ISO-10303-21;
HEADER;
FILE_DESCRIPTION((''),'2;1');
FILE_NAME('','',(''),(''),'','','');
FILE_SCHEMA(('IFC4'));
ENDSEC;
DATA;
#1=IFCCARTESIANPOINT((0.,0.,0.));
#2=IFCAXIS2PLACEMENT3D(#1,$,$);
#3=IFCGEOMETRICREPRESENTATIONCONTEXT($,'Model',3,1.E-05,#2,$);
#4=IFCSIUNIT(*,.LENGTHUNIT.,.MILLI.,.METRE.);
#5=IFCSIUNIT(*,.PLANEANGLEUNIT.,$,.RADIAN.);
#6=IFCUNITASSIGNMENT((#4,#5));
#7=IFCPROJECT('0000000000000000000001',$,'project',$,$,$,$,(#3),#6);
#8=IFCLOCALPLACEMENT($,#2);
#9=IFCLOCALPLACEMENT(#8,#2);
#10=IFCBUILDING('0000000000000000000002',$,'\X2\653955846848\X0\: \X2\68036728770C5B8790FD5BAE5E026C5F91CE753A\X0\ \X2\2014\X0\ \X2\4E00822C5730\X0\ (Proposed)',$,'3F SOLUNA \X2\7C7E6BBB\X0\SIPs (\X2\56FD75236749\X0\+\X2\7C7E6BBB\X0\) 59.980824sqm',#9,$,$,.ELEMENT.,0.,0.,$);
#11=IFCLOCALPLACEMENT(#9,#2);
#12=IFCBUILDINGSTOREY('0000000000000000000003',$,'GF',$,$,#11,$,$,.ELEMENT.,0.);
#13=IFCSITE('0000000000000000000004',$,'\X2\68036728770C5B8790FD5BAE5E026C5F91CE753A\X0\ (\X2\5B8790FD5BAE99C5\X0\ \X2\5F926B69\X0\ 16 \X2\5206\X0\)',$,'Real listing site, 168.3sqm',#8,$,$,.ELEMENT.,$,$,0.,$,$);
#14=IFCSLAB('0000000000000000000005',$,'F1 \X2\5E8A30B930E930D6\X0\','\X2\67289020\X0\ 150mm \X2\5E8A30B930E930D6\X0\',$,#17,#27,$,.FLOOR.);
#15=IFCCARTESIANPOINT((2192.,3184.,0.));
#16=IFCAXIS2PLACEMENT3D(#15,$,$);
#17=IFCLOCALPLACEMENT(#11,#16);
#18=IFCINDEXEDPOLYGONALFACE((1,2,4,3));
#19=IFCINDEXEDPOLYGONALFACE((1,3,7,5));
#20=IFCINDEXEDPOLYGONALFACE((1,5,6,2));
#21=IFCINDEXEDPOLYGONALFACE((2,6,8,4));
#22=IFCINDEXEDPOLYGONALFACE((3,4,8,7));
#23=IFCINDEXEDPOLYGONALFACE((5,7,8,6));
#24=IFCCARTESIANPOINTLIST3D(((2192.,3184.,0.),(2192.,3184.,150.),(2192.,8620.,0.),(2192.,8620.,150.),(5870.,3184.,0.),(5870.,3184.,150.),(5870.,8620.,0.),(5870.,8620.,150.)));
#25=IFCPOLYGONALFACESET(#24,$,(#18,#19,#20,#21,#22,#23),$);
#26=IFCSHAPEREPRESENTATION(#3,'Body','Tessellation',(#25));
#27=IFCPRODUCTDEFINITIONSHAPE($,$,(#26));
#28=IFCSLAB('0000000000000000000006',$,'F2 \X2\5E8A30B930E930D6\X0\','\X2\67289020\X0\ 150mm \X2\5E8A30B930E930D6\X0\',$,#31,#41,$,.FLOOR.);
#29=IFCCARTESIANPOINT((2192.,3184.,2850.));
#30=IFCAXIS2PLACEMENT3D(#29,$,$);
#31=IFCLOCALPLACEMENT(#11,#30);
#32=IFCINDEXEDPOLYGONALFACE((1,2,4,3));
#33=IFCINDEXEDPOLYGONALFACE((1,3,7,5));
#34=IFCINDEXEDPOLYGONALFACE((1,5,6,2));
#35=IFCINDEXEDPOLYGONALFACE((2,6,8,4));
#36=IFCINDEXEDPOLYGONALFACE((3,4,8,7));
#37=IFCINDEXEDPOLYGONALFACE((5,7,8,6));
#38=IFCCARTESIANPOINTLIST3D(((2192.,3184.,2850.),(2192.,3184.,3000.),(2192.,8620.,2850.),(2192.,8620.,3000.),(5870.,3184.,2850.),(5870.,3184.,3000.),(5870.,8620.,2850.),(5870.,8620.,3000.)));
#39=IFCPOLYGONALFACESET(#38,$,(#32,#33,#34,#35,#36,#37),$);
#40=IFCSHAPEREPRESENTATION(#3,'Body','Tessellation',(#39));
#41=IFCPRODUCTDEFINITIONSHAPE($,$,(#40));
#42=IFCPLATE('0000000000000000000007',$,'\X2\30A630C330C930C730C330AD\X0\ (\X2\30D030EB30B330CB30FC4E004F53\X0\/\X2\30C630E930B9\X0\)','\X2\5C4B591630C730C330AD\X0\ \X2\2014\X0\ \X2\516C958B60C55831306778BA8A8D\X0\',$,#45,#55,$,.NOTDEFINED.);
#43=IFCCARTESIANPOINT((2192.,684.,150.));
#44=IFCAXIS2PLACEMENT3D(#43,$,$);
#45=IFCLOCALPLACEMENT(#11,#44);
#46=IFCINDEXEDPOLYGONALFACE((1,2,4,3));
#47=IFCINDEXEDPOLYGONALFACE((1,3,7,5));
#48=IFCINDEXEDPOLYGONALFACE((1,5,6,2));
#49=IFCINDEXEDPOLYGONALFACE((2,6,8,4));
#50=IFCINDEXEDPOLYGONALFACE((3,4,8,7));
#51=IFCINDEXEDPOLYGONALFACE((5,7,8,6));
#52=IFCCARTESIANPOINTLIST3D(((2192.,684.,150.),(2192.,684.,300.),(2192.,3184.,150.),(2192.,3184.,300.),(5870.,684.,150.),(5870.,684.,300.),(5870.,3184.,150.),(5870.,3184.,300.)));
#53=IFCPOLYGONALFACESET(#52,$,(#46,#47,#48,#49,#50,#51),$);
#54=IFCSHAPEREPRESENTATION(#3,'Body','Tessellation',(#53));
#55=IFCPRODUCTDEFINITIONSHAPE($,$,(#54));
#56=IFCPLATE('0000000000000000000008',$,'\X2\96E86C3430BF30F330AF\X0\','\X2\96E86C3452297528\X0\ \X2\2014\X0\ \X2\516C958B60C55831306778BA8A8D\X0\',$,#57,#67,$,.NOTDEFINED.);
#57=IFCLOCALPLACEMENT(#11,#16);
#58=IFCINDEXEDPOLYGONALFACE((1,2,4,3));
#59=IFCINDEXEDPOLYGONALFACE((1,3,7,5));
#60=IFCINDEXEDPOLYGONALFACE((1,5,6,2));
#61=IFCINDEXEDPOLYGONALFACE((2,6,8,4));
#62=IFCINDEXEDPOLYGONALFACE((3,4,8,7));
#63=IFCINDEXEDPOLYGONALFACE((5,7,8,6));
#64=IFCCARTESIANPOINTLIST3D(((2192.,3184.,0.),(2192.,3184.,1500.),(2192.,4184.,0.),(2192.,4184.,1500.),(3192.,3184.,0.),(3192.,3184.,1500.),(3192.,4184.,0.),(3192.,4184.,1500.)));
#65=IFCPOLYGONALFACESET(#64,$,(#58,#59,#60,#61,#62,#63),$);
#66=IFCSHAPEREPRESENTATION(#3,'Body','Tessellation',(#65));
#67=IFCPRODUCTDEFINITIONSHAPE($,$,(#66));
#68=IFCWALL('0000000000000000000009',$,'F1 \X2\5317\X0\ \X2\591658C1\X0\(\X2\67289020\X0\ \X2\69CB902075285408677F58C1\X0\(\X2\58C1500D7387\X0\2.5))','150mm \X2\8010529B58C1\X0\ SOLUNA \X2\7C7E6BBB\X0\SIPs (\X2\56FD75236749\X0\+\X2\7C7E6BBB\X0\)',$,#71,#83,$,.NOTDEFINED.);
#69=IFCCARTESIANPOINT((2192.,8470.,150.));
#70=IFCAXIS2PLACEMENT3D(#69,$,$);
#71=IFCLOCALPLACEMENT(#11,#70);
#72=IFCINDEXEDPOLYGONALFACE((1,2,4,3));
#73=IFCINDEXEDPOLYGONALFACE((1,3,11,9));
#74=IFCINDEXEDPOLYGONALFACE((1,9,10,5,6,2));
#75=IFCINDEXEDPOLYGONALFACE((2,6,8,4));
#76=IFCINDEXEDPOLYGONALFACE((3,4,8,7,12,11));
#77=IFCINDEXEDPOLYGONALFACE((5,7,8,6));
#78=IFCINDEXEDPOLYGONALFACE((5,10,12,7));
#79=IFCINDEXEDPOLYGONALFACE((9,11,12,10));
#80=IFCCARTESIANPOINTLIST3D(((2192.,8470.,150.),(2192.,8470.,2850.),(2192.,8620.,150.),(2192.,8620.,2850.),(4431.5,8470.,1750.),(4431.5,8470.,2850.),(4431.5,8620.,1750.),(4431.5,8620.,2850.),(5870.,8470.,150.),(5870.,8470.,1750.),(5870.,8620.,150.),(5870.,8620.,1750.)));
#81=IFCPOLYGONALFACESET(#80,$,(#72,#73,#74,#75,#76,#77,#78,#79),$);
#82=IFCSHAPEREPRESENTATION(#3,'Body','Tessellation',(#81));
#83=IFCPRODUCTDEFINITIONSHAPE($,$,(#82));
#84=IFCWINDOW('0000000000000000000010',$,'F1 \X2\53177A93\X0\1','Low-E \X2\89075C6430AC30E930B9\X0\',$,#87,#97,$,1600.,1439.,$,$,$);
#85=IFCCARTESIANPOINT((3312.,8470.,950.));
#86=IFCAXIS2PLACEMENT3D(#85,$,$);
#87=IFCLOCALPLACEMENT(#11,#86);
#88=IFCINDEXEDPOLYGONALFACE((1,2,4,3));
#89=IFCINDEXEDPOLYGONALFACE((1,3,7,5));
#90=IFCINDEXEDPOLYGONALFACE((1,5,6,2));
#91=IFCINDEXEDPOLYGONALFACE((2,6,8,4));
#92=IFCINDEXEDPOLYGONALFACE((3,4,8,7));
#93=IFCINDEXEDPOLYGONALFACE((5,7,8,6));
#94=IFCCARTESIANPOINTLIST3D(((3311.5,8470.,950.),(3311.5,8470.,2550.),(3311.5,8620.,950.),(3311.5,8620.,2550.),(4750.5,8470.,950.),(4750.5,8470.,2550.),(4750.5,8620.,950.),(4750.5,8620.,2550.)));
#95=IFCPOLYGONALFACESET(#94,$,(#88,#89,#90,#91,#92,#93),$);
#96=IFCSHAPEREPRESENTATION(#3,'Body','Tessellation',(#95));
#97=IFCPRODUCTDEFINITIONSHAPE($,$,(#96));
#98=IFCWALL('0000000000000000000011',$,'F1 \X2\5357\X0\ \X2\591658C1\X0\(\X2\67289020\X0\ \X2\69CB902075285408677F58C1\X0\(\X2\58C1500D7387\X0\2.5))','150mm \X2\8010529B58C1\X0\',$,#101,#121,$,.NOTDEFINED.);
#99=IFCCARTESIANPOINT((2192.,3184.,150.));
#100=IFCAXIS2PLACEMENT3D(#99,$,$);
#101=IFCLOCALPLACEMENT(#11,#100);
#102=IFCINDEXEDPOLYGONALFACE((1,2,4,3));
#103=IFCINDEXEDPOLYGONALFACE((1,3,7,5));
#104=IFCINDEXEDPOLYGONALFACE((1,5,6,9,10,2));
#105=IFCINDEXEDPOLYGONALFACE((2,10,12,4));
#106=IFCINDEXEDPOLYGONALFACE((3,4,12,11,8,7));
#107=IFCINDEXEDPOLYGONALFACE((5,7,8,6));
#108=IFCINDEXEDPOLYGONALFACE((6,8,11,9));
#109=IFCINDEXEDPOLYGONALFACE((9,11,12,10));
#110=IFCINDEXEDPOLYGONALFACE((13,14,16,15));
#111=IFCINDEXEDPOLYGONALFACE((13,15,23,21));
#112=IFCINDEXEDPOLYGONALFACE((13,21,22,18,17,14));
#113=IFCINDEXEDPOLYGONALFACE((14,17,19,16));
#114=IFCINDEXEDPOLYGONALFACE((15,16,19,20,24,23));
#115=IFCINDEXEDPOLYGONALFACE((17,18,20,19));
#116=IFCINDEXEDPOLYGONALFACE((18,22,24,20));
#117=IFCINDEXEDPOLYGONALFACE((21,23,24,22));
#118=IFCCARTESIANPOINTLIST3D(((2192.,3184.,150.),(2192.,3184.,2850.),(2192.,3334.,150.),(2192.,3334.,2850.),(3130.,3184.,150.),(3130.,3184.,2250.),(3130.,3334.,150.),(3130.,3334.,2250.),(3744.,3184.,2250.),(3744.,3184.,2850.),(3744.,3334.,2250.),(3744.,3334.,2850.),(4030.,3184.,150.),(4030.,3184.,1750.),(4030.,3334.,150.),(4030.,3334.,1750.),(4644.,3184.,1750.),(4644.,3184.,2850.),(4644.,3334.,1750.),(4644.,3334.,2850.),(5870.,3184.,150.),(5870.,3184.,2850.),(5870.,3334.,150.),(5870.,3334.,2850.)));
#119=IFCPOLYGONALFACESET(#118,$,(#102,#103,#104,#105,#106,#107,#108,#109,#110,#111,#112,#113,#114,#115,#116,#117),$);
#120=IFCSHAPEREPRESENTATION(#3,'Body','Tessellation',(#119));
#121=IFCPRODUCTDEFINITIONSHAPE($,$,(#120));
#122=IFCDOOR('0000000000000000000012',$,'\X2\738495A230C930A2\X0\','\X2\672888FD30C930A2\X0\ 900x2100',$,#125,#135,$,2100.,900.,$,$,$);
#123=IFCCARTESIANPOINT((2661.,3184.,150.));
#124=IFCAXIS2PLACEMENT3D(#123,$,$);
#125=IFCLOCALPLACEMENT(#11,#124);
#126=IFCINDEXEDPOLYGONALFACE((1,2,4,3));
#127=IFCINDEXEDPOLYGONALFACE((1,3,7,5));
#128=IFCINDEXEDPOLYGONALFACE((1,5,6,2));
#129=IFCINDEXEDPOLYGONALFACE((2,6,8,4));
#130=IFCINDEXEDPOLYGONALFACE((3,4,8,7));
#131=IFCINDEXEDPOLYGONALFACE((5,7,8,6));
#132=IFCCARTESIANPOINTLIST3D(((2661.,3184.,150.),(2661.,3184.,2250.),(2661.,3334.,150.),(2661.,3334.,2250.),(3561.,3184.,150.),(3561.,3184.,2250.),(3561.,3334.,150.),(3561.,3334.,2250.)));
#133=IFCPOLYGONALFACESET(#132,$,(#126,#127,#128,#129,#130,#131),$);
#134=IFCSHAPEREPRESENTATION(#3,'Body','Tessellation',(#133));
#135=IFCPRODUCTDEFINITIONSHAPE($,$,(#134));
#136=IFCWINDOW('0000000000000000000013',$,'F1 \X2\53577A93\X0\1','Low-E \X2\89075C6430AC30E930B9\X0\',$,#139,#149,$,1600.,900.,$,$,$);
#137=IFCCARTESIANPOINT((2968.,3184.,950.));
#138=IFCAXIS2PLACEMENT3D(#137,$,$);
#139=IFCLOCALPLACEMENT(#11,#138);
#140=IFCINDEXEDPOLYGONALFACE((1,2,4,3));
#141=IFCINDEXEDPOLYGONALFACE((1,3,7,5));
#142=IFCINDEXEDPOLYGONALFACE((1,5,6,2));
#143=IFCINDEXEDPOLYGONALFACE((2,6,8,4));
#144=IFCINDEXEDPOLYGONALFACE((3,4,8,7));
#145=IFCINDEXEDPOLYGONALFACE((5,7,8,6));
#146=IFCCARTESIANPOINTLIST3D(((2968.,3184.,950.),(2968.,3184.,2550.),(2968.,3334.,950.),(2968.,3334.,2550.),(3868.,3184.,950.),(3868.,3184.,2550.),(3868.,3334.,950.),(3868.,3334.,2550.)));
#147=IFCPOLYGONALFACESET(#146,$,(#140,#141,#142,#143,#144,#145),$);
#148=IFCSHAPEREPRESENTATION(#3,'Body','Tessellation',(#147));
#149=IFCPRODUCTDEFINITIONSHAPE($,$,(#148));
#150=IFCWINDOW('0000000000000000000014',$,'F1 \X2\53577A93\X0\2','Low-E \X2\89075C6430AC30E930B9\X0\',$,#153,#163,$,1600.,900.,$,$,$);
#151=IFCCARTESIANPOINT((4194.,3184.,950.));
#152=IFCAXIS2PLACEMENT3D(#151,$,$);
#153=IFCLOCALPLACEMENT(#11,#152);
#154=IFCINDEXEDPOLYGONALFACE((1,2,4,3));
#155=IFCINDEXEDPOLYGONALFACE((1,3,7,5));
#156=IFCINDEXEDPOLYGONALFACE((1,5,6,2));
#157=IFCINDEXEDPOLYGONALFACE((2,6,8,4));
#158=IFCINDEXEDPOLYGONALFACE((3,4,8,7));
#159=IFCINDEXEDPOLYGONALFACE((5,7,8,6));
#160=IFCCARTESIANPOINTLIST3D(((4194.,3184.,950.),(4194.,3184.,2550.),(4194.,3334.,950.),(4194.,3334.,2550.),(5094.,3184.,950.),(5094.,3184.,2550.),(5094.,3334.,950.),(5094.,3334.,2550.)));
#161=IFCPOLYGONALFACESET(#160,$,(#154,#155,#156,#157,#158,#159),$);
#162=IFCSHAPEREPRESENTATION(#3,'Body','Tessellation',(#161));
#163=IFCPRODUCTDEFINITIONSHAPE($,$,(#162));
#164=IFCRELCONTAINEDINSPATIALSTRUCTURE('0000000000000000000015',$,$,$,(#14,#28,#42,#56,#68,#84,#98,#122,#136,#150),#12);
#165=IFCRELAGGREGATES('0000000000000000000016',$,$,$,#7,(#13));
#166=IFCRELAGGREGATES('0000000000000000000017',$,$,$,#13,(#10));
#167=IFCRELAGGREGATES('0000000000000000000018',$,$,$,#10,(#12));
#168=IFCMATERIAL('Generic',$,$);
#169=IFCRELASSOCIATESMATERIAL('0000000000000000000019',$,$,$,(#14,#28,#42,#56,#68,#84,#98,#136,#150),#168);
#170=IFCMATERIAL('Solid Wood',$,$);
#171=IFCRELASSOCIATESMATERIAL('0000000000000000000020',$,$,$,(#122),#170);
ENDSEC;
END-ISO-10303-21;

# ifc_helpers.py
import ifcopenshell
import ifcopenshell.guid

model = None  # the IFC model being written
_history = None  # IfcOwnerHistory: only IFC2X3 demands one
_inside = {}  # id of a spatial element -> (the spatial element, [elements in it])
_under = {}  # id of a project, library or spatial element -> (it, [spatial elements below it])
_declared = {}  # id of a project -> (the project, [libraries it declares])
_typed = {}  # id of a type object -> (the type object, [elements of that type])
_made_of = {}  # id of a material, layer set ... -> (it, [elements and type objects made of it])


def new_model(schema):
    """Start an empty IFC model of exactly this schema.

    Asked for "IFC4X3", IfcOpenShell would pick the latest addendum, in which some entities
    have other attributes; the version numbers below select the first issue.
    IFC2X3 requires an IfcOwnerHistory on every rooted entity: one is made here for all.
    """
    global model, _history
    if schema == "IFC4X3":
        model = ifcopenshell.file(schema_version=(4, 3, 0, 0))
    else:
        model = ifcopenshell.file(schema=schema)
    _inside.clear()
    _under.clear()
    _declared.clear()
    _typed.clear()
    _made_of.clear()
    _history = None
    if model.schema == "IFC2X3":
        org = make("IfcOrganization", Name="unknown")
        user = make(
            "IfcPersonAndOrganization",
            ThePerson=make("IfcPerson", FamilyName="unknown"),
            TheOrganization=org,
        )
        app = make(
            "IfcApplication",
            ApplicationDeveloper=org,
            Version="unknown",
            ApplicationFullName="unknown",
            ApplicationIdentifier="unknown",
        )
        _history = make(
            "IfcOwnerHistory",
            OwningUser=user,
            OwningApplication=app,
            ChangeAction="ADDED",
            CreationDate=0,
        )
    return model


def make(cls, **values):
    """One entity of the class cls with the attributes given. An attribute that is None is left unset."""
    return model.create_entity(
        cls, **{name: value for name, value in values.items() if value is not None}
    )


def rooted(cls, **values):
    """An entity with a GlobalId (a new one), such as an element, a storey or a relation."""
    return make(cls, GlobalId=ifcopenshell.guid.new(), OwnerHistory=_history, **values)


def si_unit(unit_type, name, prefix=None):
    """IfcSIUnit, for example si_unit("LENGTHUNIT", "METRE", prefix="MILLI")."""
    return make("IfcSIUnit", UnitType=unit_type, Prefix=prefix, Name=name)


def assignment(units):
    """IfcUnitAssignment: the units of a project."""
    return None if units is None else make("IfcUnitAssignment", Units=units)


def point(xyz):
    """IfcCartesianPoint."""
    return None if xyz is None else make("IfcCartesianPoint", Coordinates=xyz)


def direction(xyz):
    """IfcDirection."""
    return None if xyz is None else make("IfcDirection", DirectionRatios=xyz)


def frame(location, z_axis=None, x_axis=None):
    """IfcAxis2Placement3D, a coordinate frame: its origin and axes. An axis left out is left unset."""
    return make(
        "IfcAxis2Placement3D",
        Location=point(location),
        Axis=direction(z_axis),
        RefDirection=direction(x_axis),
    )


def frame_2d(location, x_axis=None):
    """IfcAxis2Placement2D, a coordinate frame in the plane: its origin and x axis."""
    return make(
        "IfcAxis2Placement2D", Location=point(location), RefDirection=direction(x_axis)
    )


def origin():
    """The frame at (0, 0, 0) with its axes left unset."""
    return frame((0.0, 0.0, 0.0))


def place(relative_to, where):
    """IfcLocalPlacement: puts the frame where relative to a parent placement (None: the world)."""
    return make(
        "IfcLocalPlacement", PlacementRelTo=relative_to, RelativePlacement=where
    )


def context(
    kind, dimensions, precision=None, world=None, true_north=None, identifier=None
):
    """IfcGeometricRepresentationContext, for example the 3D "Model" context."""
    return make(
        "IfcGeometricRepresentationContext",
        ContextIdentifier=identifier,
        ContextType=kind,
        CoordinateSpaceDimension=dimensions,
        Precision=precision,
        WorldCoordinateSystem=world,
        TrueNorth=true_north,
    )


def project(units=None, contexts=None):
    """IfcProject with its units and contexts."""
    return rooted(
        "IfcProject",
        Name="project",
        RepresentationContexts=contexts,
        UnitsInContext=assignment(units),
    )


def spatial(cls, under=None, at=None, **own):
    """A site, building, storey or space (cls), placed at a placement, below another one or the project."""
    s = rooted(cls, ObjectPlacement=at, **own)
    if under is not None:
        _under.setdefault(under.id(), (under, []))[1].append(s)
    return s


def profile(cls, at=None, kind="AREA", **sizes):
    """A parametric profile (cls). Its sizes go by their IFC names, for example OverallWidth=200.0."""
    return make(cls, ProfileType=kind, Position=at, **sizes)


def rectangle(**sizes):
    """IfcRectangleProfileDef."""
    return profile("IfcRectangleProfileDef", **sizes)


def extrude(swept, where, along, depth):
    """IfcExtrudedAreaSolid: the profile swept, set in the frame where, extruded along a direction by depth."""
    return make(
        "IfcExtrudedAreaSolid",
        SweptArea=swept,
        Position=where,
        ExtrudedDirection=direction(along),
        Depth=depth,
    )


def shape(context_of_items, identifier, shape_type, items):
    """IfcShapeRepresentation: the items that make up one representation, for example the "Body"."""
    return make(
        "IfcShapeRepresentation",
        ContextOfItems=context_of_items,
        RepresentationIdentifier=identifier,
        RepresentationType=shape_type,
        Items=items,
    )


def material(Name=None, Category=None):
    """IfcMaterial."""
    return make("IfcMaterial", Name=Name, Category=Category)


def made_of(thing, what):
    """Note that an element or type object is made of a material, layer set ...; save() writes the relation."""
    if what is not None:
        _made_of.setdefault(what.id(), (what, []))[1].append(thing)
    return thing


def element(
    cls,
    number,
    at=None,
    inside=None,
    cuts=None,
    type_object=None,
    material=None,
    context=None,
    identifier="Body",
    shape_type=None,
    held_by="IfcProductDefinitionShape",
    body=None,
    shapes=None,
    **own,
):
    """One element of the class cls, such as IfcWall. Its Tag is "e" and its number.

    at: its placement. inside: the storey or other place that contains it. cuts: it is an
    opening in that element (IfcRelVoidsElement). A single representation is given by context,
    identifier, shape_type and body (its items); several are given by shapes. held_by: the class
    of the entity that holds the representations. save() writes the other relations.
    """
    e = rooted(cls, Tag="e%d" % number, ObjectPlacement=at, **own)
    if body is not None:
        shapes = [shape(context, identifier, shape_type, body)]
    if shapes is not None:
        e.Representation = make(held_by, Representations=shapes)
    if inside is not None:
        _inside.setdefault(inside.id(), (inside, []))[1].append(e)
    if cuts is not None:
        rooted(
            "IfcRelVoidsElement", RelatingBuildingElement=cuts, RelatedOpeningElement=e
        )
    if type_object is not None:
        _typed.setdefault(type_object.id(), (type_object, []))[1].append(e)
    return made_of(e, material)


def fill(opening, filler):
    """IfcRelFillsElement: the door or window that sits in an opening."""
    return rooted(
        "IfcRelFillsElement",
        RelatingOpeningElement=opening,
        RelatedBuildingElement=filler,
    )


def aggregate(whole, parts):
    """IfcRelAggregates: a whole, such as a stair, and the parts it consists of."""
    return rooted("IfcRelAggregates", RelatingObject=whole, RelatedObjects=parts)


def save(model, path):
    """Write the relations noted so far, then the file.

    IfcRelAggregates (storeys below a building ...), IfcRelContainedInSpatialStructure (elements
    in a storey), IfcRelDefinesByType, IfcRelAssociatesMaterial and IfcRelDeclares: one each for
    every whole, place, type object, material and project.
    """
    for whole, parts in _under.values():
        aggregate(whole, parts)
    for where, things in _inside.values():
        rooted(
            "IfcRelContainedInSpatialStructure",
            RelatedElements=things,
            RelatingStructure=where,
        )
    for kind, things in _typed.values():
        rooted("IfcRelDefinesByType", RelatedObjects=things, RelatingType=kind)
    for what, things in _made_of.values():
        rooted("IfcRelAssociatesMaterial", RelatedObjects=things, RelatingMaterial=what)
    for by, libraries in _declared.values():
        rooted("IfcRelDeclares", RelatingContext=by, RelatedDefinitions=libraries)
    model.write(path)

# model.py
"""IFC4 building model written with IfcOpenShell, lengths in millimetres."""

from ifc_helpers import new_model, si_unit, frame, frame_2d, origin, place, context, project, spatial, rectangle, extrude, material, element, fill, save


model = new_model("IFC4")

# Units and contexts
model_context = context("Model", 3, precision=1e-05, world=origin())
ifc_project = project(units=[si_unit("LENGTHUNIT", "METRE", prefix="MILLI"), si_unit("PLANEANGLEUNIT", "RADIAN")], contexts=[model_context])

# Site, building, storey
site_placement = place(None, origin())
site = spatial("IfcSite", under=ifc_project, at=site_placement, Name="栃木県宇都宮市江野町 (宇都宮駅 徒歩 16 分)", ObjectType="Real listing site, 168.3sqm", CompositionType="ELEMENT", RefElevation=0.0)
building_placement = place(site_placement, origin())
building = spatial("IfcBuilding", under=site, at=building_placement, Name="改善案: 栃木県宇都宮市江野町 — 一般地 (Proposed)", ObjectType="3F SOLUNA 籾殻SIPs (国産杉+籾殻) 59.980824sqm", CompositionType="ELEMENT", ElevationOfRefHeight=0.0, ElevationOfTerrain=0.0)
storey_placement = place(building_placement, origin())
storey = spatial("IfcBuildingStorey", under=building, at=storey_placement, Name="GF", CompositionType="ELEMENT", Elevation=0.0)

# Slabs
ifc_material_1 = material(Name="Generic")
slab_1_placement = place(storey_placement, frame((2192.0, 3184.0, 0.0)))
element("IfcSlab", 1, at=slab_1_placement, inside=storey, material=ifc_material_1, Name="F1 床スラブ", Description="木造 150mm 床スラブ", PredefinedType="FLOOR", context=model_context, shape_type="SweptSolid", body=[
    extrude(rectangle(XDim=3678.0, YDim=5436.0, at=frame_2d((1839.0, 2718.0))), frame((2192.0, 3184.0, 0.0)), (0.0, 0.0, 1.0), 150.0),
])
slab_2_placement = place(storey_placement, frame((2192.0, 3184.0, 2850.0)))
element("IfcSlab", 2, at=slab_2_placement, inside=storey, material=ifc_material_1, Name="F2 床スラブ", Description="木造 150mm 床スラブ", PredefinedType="FLOOR", context=model_context, shape_type="SweptSolid", body=[
    extrude(rectangle(XDim=3678.0, YDim=5436.0, at=frame_2d((1839.0, 2718.0))), frame((2192.0, 3184.0, 2850.0)), (0.0, 0.0, 1.0), 150.0),
])

# Plates
plate_1_placement = place(storey_placement, frame((2192.0, 684.0, 150.0)))
element("IfcPlate", 3, at=plate_1_placement, inside=storey, material=ifc_material_1, Name="ウッドデッキ (バルコニー一体/テラス)", Description="屋外デッキ — 公開情報で確認", PredefinedType="NOTDEFINED", context=model_context, shape_type="SweptSolid", body=[
    extrude(rectangle(XDim=3678.0, YDim=2500.0, at=frame_2d((1839.0, 1250.0))), frame((2192.0, 684.0, 150.0)), (0.0, 0.0, 1.0), 150.0),
])
plate_2_placement = place(storey_placement, frame((2192.0, 3184.0, 0.0)))
element("IfcPlate", 4, at=plate_2_placement, inside=storey, material=ifc_material_1, Name="雨水タンク", Description="雨水利用 — 公開情報で確認", PredefinedType="NOTDEFINED", context=model_context, shape_type="SweptSolid", body=[
    extrude(rectangle(XDim=1000.0, YDim=1000.0, at=frame_2d((500.0, 500.0))), frame((2192.0, 3184.0, 0.0)), (0.0, 0.0, 1.0), 1500.0),
])

# Wall, opening, window
wall_1_placement = place(storey_placement, frame((2192.0, 8470.0, 150.0)))
wall_1 = element("IfcWall", 5, at=wall_1_placement, inside=storey, material=ifc_material_1, Name="F1 北 外壁(木造 構造用合板壁(壁倍率2.5))", Description="150mm 耐力壁 SOLUNA 籾殻SIPs (国産杉+籾殻)", PredefinedType="NOTDEFINED", context=model_context, shape_type="SweptSolid", body=[
    extrude(rectangle(XDim=3678.0, YDim=150.0, at=frame_2d((1839.0, 75.0))), frame((2192.0, 8470.0, 150.0)), (0.0, 0.0, 1.0), 2700.0),
])
opening_1_placement = place(storey_placement, frame((3312.0, 8470.0, 950.0)))
opening_1 = element("IfcOpeningElement", 6, at=opening_1_placement, cuts=wall_1, PredefinedType="NOTDEFINED", context=model_context, shape_type="SweptSolid", body=[
    extrude(rectangle(XDim=1439.0, YDim=150.0, at=frame_2d((719.0, 75.0))), frame((3312.0, 8470.0, 950.0)), (0.0, 0.0, 1.0), 1600.0),
])
window_1_placement = place(storey_placement, frame((3312.0, 8470.0, 950.0)))
window_1 = element("IfcWindow", 7, at=window_1_placement, inside=storey, material=ifc_material_1, Name="F1 北窓1", Description="Low-E 複層ガラス", OverallHeight=1600.0, OverallWidth=1439.0, context=model_context, shape_type="SweptSolid", body=[
    extrude(rectangle(XDim=1439.0, YDim=150.0, at=frame_2d((719.0, 75.0))), frame((3312.0, 8470.0, 950.0)), (0.0, 0.0, 1.0), 1600.0),
])
fill(opening_1, window_1)

# Wall, openings, door, windows
wall_2_placement = place(storey_placement, frame((2192.0, 3184.0, 150.0)))
wall_2 = element("IfcWall", 8, at=wall_2_placement, inside=storey, material=ifc_material_1, Name="F1 南 外壁(木造 構造用合板壁(壁倍率2.5))", Description="150mm 耐力壁", PredefinedType="NOTDEFINED", context=model_context, shape_type="SweptSolid", body=[
    extrude(rectangle(XDim=3678.0, YDim=150.0, at=frame_2d((1839.0, 75.0))), frame((2192.0, 3184.0, 150.0)), (0.0, 0.0, 1.0), 2700.0),
])
opening_2_placement = place(storey_placement, frame((2661.0, 3184.0, 150.0)))
opening_2 = element("IfcOpeningElement", 9, at=opening_2_placement, cuts=wall_2, PredefinedType="NOTDEFINED", context=model_context, shape_type="SweptSolid", body=[
    extrude(rectangle(XDim=900.0, YDim=150.0, at=frame_2d((450.0, 75.0))), frame((2661.0, 3184.0, 150.0)), (0.0, 0.0, 1.0), 2100.0),
])
opening_3_placement = place(storey_placement, frame((2968.0, 3184.0, 950.0)))
opening_3 = element("IfcOpeningElement", 10, at=opening_3_placement, cuts=wall_2, PredefinedType="NOTDEFINED", context=model_context, shape_type="SweptSolid", body=[
    extrude(rectangle(XDim=900.0, YDim=150.0, at=frame_2d((450.0, 75.0))), frame((2968.0, 3184.0, 950.0)), (0.0, 0.0, 1.0), 1600.0),
])
opening_4_placement = place(storey_placement, frame((4194.0, 3184.0, 950.0)))
opening_4 = element("IfcOpeningElement", 11, at=opening_4_placement, cuts=wall_2, PredefinedType="NOTDEFINED", context=model_context, shape_type="SweptSolid", body=[
    extrude(rectangle(XDim=900.0, YDim=150.0, at=frame_2d((450.0, 75.0))), frame((4194.0, 3184.0, 950.0)), (0.0, 0.0, 1.0), 1600.0),
])
ifc_material_2 = material(Name="Solid Wood")
door_placement = place(storey_placement, frame((2661.0, 3184.0, 150.0)))
door = element("IfcDoor", 12, at=door_placement, inside=storey, material=ifc_material_2, Name="玄関ドア", Description="木製ドア 900x2100", OverallHeight=2100.0, OverallWidth=900.0, context=model_context, shape_type="SweptSolid", body=[
    extrude(rectangle(XDim=900.0, YDim=150.0, at=frame_2d((450.0, 75.0))), frame((2661.0, 3184.0, 150.0)), (0.0, 0.0, 1.0), 2100.0),
])
fill(opening_2, door)
window_2_placement = place(storey_placement, frame((2968.0, 3184.0, 950.0)))
window_2 = element("IfcWindow", 13, at=window_2_placement, inside=storey, material=ifc_material_1, Name="F1 南窓1", Description="Low-E 複層ガラス", OverallHeight=1600.0, OverallWidth=900.0, context=model_context, shape_type="SweptSolid", body=[
    extrude(rectangle(XDim=900.0, YDim=150.0, at=frame_2d((450.0, 75.0))), frame((2968.0, 3184.0, 950.0)), (0.0, 0.0, 1.0), 1600.0),
])
fill(opening_3, window_2)
window_3_placement = place(storey_placement, frame((4194.0, 3184.0, 950.0)))
window_3 = element("IfcWindow", 14, at=window_3_placement, inside=storey, material=ifc_material_1, Name="F1 南窓2", Description="Low-E 複層ガラス", OverallHeight=1600.0, OverallWidth=900.0, context=model_context, shape_type="SweptSolid", body=[
    extrude(rectangle(XDim=900.0, YDim=150.0, at=frame_2d((450.0, 75.0))), frame((4194.0, 3184.0, 950.0)), (0.0, 0.0, 1.0), 1600.0),
])
fill(opening_4, window_3)

save(model, "model.ifc")
